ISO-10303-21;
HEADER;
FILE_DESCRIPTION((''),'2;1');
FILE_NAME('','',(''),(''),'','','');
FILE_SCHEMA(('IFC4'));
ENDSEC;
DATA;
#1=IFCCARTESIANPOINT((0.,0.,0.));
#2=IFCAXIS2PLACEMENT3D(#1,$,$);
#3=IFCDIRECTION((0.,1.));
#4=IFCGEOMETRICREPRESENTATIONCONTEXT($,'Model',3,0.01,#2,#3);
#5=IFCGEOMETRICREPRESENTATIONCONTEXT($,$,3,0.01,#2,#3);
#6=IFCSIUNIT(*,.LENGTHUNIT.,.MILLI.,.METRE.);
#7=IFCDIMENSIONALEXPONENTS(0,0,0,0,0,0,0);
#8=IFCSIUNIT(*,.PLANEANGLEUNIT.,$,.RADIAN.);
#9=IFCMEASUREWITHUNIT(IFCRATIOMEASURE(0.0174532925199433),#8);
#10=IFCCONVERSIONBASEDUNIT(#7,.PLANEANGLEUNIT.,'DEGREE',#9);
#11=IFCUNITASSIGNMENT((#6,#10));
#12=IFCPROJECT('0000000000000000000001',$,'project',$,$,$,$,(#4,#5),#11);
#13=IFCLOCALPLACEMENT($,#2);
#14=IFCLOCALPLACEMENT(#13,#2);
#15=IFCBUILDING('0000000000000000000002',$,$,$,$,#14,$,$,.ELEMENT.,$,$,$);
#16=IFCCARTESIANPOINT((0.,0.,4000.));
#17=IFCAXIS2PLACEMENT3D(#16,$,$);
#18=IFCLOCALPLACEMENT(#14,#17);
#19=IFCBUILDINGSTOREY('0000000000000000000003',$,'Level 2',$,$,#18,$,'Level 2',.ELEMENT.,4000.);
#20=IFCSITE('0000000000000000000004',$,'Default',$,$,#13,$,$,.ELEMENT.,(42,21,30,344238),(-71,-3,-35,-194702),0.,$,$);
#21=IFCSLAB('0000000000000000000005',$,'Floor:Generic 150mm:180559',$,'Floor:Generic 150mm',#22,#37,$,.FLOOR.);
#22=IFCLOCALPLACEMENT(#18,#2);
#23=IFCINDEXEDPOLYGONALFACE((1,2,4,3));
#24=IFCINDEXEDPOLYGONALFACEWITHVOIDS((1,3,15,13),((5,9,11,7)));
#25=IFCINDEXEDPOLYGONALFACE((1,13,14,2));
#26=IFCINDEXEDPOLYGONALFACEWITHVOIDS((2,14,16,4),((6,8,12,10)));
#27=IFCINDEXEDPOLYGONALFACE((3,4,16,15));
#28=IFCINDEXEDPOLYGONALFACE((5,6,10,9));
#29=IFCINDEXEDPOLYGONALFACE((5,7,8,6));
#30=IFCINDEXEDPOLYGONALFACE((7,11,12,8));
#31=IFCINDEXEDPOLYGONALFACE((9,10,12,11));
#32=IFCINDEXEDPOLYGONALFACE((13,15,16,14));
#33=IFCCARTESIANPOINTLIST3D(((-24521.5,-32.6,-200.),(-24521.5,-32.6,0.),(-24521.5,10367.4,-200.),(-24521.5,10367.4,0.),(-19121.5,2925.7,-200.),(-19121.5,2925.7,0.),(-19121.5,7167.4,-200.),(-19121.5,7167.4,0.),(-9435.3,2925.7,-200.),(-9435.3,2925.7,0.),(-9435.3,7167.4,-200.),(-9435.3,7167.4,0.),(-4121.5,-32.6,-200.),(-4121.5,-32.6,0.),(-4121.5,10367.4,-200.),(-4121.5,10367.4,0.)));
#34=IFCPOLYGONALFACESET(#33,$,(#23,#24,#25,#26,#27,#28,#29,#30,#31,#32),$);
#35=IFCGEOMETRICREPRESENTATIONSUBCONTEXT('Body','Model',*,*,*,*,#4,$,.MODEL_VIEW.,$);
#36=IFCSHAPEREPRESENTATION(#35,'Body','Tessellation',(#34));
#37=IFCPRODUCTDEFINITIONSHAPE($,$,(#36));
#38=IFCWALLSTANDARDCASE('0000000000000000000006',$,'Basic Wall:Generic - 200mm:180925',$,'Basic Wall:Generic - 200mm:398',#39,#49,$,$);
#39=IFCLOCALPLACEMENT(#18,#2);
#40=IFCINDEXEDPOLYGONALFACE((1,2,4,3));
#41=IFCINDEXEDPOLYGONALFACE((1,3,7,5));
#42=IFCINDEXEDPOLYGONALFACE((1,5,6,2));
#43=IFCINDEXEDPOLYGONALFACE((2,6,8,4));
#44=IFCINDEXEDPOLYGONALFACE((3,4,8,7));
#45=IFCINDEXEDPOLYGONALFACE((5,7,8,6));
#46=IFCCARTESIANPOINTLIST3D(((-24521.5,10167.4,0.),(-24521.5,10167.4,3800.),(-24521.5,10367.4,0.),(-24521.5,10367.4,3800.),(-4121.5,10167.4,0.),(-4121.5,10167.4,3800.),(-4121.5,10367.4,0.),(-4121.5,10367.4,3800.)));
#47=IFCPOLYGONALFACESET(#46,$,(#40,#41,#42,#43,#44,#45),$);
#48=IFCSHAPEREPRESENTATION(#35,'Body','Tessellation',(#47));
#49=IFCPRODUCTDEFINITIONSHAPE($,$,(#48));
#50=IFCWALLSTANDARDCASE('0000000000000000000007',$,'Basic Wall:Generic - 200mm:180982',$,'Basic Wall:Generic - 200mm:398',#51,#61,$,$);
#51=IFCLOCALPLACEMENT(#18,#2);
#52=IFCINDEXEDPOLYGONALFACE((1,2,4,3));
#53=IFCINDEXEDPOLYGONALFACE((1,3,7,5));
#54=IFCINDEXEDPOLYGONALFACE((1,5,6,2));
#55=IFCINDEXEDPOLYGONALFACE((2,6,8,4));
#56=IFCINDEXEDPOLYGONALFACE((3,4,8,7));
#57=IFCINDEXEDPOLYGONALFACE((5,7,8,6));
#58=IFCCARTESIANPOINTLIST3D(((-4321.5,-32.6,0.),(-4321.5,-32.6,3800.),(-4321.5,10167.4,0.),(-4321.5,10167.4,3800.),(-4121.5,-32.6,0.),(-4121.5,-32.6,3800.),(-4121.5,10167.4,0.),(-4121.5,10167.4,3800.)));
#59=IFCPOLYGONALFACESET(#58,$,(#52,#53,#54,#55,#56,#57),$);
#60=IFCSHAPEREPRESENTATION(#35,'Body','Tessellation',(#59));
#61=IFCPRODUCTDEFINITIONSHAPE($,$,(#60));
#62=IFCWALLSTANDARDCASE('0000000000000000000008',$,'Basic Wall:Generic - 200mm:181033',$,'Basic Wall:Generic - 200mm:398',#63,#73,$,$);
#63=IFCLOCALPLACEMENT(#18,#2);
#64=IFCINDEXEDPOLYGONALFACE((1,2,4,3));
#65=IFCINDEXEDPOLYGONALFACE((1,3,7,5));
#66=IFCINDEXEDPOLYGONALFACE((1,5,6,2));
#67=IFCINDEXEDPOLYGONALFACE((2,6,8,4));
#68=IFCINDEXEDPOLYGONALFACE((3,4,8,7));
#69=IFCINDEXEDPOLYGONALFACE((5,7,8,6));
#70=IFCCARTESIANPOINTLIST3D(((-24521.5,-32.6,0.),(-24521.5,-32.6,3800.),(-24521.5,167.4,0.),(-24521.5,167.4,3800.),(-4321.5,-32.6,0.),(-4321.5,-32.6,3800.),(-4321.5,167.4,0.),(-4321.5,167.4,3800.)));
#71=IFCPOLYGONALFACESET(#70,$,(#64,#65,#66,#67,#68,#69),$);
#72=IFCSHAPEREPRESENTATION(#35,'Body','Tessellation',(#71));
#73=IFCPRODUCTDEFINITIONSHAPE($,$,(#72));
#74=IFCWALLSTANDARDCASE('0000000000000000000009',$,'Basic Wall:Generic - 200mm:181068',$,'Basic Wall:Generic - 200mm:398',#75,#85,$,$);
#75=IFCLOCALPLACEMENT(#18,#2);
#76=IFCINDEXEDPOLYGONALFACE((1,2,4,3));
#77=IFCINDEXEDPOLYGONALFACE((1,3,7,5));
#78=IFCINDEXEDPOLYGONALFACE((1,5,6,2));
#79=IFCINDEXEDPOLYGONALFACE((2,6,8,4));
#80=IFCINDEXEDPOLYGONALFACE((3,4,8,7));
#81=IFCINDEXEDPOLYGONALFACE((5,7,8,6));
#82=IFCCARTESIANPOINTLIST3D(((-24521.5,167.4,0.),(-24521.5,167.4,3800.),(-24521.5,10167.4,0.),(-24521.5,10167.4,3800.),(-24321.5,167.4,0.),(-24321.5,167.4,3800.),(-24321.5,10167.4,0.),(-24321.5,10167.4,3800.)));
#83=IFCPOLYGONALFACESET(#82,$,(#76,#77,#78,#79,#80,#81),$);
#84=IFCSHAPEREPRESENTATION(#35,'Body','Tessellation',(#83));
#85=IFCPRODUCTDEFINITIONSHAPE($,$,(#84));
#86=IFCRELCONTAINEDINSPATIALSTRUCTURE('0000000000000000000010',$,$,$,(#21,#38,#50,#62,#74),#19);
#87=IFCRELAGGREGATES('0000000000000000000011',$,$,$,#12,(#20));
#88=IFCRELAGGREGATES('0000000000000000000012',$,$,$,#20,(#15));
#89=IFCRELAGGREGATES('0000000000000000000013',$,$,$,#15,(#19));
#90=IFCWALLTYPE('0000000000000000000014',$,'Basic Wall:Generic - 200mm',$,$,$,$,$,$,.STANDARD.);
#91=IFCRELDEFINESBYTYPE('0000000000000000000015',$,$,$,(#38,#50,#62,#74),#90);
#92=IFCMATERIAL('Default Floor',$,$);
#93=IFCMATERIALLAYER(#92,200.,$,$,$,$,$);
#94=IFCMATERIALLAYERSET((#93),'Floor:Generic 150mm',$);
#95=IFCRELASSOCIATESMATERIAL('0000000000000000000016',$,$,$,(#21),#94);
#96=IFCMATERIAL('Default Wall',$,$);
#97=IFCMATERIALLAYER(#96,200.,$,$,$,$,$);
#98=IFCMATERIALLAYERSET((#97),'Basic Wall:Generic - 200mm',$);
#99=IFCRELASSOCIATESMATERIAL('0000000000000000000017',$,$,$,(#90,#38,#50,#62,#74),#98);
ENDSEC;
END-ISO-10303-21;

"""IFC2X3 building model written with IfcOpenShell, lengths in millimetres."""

from ifc_helpers import new_model, entity, si_unit, converted_unit, direction, frame, frame_2d, origin, origin_2d_with_axis, place, context, subcontext, project, spatial, rectangle, extrude, material, layer, layer_set, layer_usage, type_object, element, save


model = new_model("IFC2X3")

# Units and contexts
model_context = context("Model", 3, precision=0.01, world=origin(), true_north=direction((0.0, 1.0)))
context_of_model = context(None, 3, precision=0.01, world=origin(), true_north=direction((0.0, 1.0)))
body_context = subcontext(model_context, "Body", "Model", "MODEL_VIEW")
ifc_project = project(units=[si_unit("LENGTHUNIT", "METRE", prefix="MILLI"), converted_unit("PLANEANGLEUNIT", "DEGREE", entity("IfcRatioMeasure", 0.0174532925199433), si_unit("PLANEANGLEUNIT", "RADIAN"), dimensions=[0, 0, 0, 0, 0, 0, 0])], contexts=[model_context, context_of_model])

# Site, building, storey
site_placement = place(None, origin())
site = spatial("IfcSite", under=ifc_project, at=site_placement, Name="Default", CompositionType="ELEMENT", RefLatitude=(42, 21, 30, 344238), RefLongitude=(-71, -3, -35, -194702), RefElevation=0.0)
building_placement = place(site_placement, origin())
building = spatial("IfcBuilding", under=site, at=building_placement, CompositionType="ELEMENT")
storey_placement = place(building_placement, frame((0.0, 0.0, 4000.0)))
storey = spatial("IfcBuildingStorey", under=building, at=storey_placement, Name="Level 2", LongName="Level 2", CompositionType="ELEMENT", Elevation=4000.0)

# Slab, opening
ifc_material_1 = material(Name="Default Floor")
ifc_layer_1 = layer(ifc_material_1, 200.0)
ifc_layer_set_1 = layer_set([ifc_layer_1], Name="Floor:Generic 150mm")
ifc_layer_usage_1 = layer_usage(ifc_layer_set_1, "AXIS3", "POSITIVE", 0.0)
slab_placement = place(storey_placement, frame((-24521.5, -32.6, -200.0)))
slab = element("IfcSlab", 1, at=slab_placement, inside=storey, material=ifc_layer_usage_1, Name="Floor:Generic 150mm:180559", ObjectType="Floor:Generic 150mm", PredefinedType="FLOOR", context=body_context, shape_type="SweptSolid", body=[
    extrude(rectangle(XDim=10400.0, YDim=20400.0, at=frame_2d((0.0, 0.0), x_axis=(0.0, -1.0))), frame((10200.0, 5200.0, 200.0), z_axis=(0.0, 0.0, -1.0), x_axis=(-1.0, 0.0, 0.0)), (0.0, 0.0, 1.0), 200.0),
])
opening_placement = place(slab_placement, frame((10243.1, 5079.1, 200.0)))
element("IfcOpeningElement", 2, at=opening_placement, cuts=slab, ObjectType="Opening", context=body_context, shape_type="SweptSolid", body=[
    extrude(rectangle(XDim=4241.7, YDim=9686.2, at=origin_2d_with_axis()), frame((0.0, 0.0, 0.0), z_axis=(0.0, 0.0, -1.0), x_axis=(0.0, -1.0, 0.0)), (0.0, 0.0, 1.0), 200.0),
])

# Walls
ifc_material_2 = material(Name="Default Wall")
ifc_layer_2 = layer(ifc_material_2, 200.0)
ifc_layer_set_2 = layer_set([ifc_layer_2], Name="Basic Wall:Generic - 200mm")
ifc_layer_usage_2 = layer_usage(ifc_layer_set_2, "AXIS2", "NEGATIVE", 100.0)
wall_type = type_object("IfcWallType", Name="Basic Wall:Generic - 200mm", PredefinedType="STANDARD", material=ifc_layer_set_2)
wall_1_placement = place(storey_placement, frame((-24521.5, 10267.4, 0.0)))
element("IfcWallStandardCase", 3, at=wall_1_placement, inside=storey, type_object=wall_type, material=ifc_layer_usage_2, Name="Basic Wall:Generic - 200mm:180925", ObjectType="Basic Wall:Generic - 200mm:398", context=body_context, shape_type="SweptSolid", body=[
    extrude(rectangle(XDim=20400.0, YDim=200.0, at=frame_2d((10200.0, 0.0), x_axis=(-1.0, 0.0))), origin(), (0.0, 0.0, 1.0), 3800.0),
])
ifc_layer_usage_3 = layer_usage(ifc_layer_set_2, "AXIS2", "NEGATIVE", 100.0)
wall_2_placement = place(storey_placement, frame((-4221.5, 10167.4, 0.0), z_axis=(0.0, 0.0, 1.0), x_axis=(0.0, -1.0, 0.0)))
element("IfcWallStandardCase", 4, at=wall_2_placement, inside=storey, type_object=wall_type, material=ifc_layer_usage_3, Name="Basic Wall:Generic - 200mm:180982", ObjectType="Basic Wall:Generic - 200mm:398", context=body_context, shape_type="SweptSolid", body=[
    extrude(rectangle(XDim=10200.0, YDim=200.0, at=frame_2d((5100.0, 0.0), x_axis=(-1.0, 0.0))), origin(), (0.0, 0.0, 1.0), 3800.0),
])
ifc_layer_usage_4 = layer_usage(ifc_layer_set_2, "AXIS2", "NEGATIVE", 100.0)
wall_3_placement = place(storey_placement, frame((-4321.5, 67.4, 0.0), z_axis=(0.0, 0.0, 1.0), x_axis=(-1.0, 0.0, 0.0)))
element("IfcWallStandardCase", 5, at=wall_3_placement, inside=storey, type_object=wall_type, material=ifc_layer_usage_4, Name="Basic Wall:Generic - 200mm:181033", ObjectType="Basic Wall:Generic - 200mm:398", context=body_context, shape_type="SweptSolid", body=[
    extrude(rectangle(XDim=20200.0, YDim=200.0, at=frame_2d((10100.0, 0.0), x_axis=(-1.0, 0.0))), origin(), (0.0, 0.0, 1.0), 3800.0),
])
ifc_layer_usage_5 = layer_usage(ifc_layer_set_2, "AXIS2", "NEGATIVE", 100.0)
wall_4_placement = place(storey_placement, frame((-24421.5, 167.4, 0.0), z_axis=(0.0, 0.0, 1.0), x_axis=(0.0, 1.0, 0.0)))
element("IfcWallStandardCase", 6, at=wall_4_placement, inside=storey, type_object=wall_type, material=ifc_layer_usage_5, Name="Basic Wall:Generic - 200mm:181068", ObjectType="Basic Wall:Generic - 200mm:398", context=body_context, shape_type="SweptSolid", body=[
    extrude(rectangle(XDim=10000.0, YDim=200.0, at=frame_2d((5000.0, 0.0), x_axis=(-1.0, 0.0))), origin(), (0.0, 0.0, 1.0), 3800.0),
])

save(model, "model.ifc")
